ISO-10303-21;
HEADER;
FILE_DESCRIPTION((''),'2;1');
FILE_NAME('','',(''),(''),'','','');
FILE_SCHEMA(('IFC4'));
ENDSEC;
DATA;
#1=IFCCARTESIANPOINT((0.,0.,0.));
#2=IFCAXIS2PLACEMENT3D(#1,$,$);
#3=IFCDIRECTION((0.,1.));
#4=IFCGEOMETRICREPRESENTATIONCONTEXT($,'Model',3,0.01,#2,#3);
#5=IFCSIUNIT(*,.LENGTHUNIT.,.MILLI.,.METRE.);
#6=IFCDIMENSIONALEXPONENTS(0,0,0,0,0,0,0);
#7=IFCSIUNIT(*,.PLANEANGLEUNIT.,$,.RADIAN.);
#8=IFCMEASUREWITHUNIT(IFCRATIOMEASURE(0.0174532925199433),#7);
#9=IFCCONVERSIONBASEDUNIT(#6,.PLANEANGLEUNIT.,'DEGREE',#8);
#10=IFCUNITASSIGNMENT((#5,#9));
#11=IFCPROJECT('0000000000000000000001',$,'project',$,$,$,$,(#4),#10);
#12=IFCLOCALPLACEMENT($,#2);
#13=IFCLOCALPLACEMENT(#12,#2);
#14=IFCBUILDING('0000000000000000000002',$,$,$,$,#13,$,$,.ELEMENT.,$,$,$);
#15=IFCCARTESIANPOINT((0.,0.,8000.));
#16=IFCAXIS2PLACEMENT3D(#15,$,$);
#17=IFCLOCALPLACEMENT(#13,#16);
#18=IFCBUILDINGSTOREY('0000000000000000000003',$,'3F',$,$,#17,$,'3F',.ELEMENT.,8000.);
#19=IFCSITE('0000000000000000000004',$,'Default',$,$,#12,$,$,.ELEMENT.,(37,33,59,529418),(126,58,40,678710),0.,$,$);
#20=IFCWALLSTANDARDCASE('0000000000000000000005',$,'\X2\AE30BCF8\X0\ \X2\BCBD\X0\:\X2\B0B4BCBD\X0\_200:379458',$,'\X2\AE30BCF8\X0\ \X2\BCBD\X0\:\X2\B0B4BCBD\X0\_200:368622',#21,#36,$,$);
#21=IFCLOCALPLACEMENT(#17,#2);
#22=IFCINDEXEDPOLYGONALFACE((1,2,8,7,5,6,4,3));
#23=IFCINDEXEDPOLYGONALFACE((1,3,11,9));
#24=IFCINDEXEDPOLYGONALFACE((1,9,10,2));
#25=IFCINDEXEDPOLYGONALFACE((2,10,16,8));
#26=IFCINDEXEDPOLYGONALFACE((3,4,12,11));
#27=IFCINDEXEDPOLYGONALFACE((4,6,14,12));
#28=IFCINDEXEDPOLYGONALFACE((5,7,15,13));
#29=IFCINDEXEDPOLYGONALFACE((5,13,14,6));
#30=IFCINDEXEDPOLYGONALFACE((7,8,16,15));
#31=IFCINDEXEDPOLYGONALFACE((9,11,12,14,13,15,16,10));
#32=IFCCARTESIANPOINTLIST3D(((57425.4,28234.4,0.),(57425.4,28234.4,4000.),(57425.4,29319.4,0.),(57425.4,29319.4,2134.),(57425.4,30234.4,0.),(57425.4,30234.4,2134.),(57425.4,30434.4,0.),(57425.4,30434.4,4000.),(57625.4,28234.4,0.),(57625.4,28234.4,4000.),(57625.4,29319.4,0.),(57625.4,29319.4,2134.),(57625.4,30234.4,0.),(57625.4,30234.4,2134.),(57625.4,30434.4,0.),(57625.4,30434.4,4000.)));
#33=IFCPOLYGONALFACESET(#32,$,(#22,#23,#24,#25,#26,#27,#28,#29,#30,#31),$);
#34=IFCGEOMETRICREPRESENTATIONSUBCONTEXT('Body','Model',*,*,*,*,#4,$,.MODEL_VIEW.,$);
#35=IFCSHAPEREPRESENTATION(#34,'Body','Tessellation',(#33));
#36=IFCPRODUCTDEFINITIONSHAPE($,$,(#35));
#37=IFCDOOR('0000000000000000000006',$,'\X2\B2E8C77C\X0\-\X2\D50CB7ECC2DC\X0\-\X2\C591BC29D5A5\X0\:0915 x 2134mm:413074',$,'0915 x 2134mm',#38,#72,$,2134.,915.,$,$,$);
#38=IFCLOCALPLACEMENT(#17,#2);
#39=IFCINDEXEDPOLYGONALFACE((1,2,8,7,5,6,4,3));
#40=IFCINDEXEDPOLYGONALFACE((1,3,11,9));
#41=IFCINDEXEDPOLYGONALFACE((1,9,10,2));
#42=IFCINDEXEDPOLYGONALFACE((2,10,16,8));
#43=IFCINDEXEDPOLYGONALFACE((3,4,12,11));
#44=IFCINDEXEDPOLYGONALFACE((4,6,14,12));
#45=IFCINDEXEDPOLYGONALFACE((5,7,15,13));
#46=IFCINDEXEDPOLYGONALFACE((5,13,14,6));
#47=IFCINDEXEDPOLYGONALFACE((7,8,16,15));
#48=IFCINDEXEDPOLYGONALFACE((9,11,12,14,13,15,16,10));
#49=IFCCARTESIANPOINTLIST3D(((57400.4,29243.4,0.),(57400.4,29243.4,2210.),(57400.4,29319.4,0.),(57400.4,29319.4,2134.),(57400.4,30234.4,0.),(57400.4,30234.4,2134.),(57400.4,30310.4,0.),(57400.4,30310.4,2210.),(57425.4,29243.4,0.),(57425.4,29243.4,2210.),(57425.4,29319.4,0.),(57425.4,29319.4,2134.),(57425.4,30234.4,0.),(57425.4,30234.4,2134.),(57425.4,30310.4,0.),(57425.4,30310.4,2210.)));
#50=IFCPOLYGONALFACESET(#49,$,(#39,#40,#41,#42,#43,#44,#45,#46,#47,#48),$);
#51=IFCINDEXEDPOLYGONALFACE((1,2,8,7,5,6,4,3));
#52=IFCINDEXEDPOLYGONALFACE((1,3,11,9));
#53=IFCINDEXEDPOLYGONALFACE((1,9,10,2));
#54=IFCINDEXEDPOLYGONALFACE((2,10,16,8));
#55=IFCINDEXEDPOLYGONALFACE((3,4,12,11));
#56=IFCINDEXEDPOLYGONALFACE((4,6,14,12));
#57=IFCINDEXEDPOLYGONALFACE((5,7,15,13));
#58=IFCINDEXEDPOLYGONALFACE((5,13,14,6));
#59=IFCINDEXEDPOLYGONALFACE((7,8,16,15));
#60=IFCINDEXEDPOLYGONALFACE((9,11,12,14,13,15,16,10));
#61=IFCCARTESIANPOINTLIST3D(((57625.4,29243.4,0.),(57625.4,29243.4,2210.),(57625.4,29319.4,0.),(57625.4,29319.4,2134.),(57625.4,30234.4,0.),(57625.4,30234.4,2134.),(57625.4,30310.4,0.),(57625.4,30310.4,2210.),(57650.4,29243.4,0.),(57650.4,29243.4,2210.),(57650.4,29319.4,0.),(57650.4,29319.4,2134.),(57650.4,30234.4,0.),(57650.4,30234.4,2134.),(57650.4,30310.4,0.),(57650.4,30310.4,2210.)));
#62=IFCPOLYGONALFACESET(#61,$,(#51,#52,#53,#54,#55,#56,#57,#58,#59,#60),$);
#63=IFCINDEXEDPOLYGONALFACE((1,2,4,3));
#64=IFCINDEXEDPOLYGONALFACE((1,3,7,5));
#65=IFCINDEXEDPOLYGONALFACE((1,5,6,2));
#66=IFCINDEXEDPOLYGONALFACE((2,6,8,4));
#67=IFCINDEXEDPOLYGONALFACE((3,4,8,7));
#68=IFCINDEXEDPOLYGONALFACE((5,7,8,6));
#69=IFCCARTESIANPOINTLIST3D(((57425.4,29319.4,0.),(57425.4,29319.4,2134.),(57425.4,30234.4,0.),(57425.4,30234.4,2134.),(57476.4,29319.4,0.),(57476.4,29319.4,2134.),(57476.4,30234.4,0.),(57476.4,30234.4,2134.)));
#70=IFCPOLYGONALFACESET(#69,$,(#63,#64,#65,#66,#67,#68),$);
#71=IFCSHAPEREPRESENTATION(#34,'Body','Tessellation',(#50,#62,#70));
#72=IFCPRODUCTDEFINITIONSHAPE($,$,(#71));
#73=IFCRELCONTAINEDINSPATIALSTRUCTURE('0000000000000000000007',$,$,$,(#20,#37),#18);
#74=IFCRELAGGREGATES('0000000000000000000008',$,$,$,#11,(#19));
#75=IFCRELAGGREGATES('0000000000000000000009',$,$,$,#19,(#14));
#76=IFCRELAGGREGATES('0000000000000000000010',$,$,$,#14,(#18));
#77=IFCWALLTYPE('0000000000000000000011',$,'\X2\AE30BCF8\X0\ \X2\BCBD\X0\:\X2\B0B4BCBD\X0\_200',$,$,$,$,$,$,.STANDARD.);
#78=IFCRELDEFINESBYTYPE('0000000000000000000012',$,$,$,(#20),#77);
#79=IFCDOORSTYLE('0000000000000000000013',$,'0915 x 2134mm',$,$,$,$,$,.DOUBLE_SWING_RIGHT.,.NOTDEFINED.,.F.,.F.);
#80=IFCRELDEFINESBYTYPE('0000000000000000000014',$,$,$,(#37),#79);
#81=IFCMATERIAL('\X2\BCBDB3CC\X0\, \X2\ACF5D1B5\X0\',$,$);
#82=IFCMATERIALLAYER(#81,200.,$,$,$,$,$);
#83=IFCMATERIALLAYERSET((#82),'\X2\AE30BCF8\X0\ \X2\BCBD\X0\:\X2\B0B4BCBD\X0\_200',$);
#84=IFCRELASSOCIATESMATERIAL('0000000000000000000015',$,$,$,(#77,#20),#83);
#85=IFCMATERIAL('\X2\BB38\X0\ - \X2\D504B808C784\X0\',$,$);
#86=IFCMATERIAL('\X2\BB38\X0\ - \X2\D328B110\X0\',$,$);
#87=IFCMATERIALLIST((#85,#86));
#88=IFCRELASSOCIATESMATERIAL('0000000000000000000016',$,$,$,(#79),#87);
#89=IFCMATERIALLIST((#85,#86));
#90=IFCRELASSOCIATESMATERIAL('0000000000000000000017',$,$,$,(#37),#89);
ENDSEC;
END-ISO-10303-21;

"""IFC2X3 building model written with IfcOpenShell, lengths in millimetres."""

from ifc_helpers import new_model, entity, si_unit, converted_unit, direction, frame, frame_2d, origin, place, context, subcontext, project, spatial, polyline, rectangle, outline, extrude, source, transform, mapped, material, material_list, layer, layer_set, layer_usage, type_object, type_shapes, element, fill, save


model = new_model("IFC2X3")

# Units and contexts
model_context = context("Model", 3, precision=0.01, world=origin(), true_north=direction((0.0, 1.0)))
body_context = subcontext(model_context, "Body", "Model", "MODEL_VIEW")
ifc_project = project(units=[si_unit("LENGTHUNIT", "METRE", prefix="MILLI"), converted_unit("PLANEANGLEUNIT", "DEGREE", entity("IfcRatioMeasure", 0.0174532925199433), si_unit("PLANEANGLEUNIT", "RADIAN"), dimensions=[0, 0, 0, 0, 0, 0, 0])], contexts=[model_context])

# Site, building, storey
site_placement = place(None, origin())
site = spatial("IfcSite", under=ifc_project, at=site_placement, Name="Default", CompositionType="ELEMENT", RefLatitude=(37, 33, 59, 529418), RefLongitude=(126, 58, 40, 678710), RefElevation=0.0)
building_placement = place(site_placement, origin())
building = spatial("IfcBuilding", under=site, at=building_placement, CompositionType="ELEMENT")
storey_placement = place(building_placement, frame((0.0, 0.0, 8000.0)))
storey = spatial("IfcBuildingStorey", under=building, at=storey_placement, Name="3F", LongName="3F", CompositionType="ELEMENT", Elevation=8000.0)

# Shared definitions
ifc_material_1 = material(Name="벽돌, 공통")
ifc_layer_1 = layer(ifc_material_1, 200.0)
ifc_layer_set_1 = layer_set([ifc_layer_1], Name="기본 벽:내벽_200")
wall_type_1 = type_object("IfcWallType", Name="기본 벽:내벽_200", PredefinedType="STANDARD", material=ifc_layer_set_1)
ifc_material_2 = material(Name="문 - 프레임")
ifc_material_3 = material(Name="문 - 패널")

# Wall, opening, door
ifc_layer_usage_1 = layer_usage(ifc_layer_set_1, "AXIS2", "NEGATIVE", 100.0)
wall_1_placement = place(storey_placement, frame((57525.4, 30434.4, 0.0), z_axis=(0.0, 0.0, 1.0), x_axis=(0.0, -1.0, 0.0)))
wall_1 = element("IfcWallStandardCase", 1, at=wall_1_placement, inside=storey, type_object=wall_type_1, material=ifc_layer_usage_1, Name="기본 벽:내벽_200:379458", ObjectType="기본 벽:내벽_200:368622", context=body_context, shape_type="SweptSolid", body=[
    extrude(rectangle(XDim=2200.0, YDim=200.0, at=frame_2d((1100.0, 0.0), x_axis=(-1.0, 0.0))), origin(), (0.0, 0.0, 1.0), 4000.0),
])
opening_1_placement = place(wall_1_placement, frame((1115.0, 100.0, 0.0)))
opening_1 = element("IfcOpeningElement", 2, at=opening_1_placement, cuts=wall_1, ObjectType="Opening", context=body_context, shape_type="SweptSolid", body=[
    extrude(rectangle(XDim=915.0, YDim=2134.0, at=frame_2d((1067.0, 457.5), x_axis=(0.0, 1.0))), frame((0.0, 0.0, 0.0), z_axis=(0.0, -1.0, 0.0), x_axis=(0.0, 0.0, 1.0)), (0.0, 0.0, 1.0), 200.0),
])
ifc_material_list_1 = material_list([ifc_material_2, ifc_material_3])
ifc_material_list_2 = material_list([ifc_material_2, ifc_material_3])
door_style_1 = type_object("IfcDoorStyle", Name="0915 x 2134mm", ConstructionType="NOTDEFINED", OperationType="DOUBLE_SWING_RIGHT", ParameterTakesPrecedence=False, Sizeable=False, material=ifc_material_list_2)
shared_shape_1 = source(origin(), body_context, "Body", "SweptSolid", [
    extrude(outline(polyline([(-533.5, -1124.0), (533.5, -1124.0), (533.5, 1086.0), (457.5, 1086.0), (457.5, -1048.0), (-457.5, -1048.0), (-457.5, 1086.0), (-533.5, 1086.0), (-533.5, -1124.0)])), frame((457.5, 200.0, 1086.0), z_axis=(0.0, 1.0, 0.0), x_axis=(1.0, 0.0, 0.0)), (0.0, 0.0, 1.0), 25.0),
    extrude(outline(polyline([(-1124.0, -533.5), (1086.0, -533.5), (1086.0, -457.5), (-1048.0, -457.5), (-1048.0, 457.5), (1086.0, 457.5), (1086.0, 533.5), (-1124.0, 533.5), (-1124.0, -533.5)])), frame((457.5, -25.0, 1086.0), z_axis=(0.0, 1.0, 0.0), x_axis=(0.0, 0.0, -1.0)), (0.0, 0.0, 1.0), 25.0),
    extrude(rectangle(XDim=51.0, YDim=915.0, at=frame_2d((0.0, 0.0), x_axis=(1.0, 0.0))), frame((457.5, 174.5, 0.0), z_axis=(0.0, 0.0, 1.0), x_axis=(0.0, 1.0, 0.0)), (0.0, 0.0, 1.0), 2134.0),
])
type_shapes(door_style_1, [shared_shape_1])
door_1_placement = place(opening_1_placement, frame((0.0, 0.0, 0.0), z_axis=(0.0, 0.0, 1.0), x_axis=(-1.0, 0.0, 0.0)))
door_1 = element("IfcDoor", 3, at=door_1_placement, inside=storey, type_object=door_style_1, material=ifc_material_list_1, Name="단일-플러시-양방향:0915 x 2134mm:413074", ObjectType="0915 x 2134mm", OverallHeight=2134.0, OverallWidth=915.0, context=body_context, shape_type="MappedRepresentation", body=[
    mapped(shared_shape_1, transform((0.0, 0.0, 0.0), scale=1.0)),
])
fill(opening_1, door_1)

save(model, "model.ifc")
